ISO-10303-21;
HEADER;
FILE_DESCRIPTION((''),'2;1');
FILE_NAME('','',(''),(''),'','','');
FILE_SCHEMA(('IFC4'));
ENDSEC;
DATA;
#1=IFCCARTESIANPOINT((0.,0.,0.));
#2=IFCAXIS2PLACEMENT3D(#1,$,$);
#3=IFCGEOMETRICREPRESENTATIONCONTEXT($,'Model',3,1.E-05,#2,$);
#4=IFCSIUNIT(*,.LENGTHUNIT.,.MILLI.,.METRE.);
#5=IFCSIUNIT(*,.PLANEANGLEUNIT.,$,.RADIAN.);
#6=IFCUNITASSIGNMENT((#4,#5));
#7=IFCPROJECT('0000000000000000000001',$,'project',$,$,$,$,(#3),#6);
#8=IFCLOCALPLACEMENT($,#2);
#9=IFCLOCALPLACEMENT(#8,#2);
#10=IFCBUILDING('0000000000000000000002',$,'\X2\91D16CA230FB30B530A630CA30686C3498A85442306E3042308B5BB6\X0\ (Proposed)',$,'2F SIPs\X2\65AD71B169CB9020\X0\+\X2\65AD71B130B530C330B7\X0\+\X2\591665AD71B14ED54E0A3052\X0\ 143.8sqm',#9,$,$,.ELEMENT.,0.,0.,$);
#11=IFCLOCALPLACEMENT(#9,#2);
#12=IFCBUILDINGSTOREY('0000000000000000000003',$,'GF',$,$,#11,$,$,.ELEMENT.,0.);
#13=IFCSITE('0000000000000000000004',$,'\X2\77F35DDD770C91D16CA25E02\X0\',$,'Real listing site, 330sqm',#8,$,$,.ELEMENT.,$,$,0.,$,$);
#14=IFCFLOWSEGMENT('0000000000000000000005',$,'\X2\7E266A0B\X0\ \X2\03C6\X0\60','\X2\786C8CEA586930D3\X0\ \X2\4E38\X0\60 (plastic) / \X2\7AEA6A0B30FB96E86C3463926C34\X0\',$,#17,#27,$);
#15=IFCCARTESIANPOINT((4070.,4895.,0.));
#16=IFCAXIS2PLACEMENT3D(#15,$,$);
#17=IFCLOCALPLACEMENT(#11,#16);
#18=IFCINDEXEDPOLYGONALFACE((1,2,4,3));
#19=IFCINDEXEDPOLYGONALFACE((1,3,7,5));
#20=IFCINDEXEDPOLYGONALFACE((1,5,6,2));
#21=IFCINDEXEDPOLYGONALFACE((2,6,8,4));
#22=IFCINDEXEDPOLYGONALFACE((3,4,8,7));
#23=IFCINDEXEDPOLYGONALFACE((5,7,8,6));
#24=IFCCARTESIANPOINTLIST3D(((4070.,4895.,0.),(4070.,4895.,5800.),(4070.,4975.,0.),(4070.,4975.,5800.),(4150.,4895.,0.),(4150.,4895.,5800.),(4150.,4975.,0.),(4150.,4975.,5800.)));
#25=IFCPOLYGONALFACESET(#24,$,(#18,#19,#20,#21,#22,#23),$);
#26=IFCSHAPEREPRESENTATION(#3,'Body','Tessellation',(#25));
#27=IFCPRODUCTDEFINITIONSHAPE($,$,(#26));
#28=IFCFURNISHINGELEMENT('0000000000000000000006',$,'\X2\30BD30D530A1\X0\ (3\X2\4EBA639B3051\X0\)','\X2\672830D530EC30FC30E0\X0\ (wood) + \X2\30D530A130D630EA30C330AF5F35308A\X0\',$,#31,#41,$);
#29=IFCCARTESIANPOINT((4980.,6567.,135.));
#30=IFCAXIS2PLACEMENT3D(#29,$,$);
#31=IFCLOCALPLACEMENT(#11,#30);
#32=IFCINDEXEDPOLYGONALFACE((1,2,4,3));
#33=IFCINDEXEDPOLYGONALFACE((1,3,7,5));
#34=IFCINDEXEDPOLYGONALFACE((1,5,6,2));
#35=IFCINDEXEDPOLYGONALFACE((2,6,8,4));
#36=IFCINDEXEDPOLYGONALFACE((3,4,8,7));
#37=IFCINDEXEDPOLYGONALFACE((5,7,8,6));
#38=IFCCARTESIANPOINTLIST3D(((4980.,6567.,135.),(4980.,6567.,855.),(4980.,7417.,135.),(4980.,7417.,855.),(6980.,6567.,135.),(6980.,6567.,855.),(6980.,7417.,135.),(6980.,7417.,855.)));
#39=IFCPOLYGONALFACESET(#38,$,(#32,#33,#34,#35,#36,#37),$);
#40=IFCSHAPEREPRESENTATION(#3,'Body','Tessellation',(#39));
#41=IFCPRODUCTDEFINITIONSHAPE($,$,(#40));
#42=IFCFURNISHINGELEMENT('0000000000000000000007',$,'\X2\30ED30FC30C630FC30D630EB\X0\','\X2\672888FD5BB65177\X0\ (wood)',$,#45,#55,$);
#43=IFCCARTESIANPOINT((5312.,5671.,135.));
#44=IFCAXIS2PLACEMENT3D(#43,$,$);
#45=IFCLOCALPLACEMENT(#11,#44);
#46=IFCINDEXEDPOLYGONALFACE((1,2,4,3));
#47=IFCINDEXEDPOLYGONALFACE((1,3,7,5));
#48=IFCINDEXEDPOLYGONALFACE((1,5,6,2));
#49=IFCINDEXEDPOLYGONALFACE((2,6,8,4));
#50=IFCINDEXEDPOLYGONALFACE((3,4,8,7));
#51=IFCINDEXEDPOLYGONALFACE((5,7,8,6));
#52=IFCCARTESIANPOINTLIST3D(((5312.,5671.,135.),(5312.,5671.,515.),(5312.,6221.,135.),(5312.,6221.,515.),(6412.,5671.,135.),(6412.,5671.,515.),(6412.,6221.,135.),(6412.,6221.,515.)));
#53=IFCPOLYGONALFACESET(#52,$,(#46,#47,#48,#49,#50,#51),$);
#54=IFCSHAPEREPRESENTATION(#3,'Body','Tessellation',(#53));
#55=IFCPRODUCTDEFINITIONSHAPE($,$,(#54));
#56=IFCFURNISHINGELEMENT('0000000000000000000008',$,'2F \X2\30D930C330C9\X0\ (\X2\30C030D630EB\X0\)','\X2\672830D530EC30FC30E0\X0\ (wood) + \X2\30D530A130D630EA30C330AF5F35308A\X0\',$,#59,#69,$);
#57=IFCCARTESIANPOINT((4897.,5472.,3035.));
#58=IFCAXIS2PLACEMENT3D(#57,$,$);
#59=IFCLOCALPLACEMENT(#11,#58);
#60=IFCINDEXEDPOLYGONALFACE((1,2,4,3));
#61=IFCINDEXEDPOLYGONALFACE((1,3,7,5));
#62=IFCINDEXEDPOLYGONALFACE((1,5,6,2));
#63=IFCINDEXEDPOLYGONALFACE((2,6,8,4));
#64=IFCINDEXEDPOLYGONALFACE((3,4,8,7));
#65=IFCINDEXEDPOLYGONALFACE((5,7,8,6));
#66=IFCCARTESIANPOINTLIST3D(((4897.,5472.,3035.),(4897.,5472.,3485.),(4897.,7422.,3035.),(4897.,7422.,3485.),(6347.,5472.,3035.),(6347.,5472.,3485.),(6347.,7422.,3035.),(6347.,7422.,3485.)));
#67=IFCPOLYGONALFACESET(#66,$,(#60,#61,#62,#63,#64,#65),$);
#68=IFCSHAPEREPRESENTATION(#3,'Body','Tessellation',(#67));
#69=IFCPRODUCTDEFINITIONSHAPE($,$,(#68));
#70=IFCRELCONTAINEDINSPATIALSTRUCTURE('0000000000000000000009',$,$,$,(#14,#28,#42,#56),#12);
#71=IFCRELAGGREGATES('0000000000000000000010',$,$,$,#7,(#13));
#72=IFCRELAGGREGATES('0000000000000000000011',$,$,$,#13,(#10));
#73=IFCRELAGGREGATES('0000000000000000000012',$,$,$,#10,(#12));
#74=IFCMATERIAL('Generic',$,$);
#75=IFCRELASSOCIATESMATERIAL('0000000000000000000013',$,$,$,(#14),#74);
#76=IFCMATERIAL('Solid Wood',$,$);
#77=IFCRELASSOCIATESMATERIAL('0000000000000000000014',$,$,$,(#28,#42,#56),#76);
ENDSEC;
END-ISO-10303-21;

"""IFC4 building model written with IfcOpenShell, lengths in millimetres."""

from ifc_helpers import new_model, si_unit, frame, frame_2d, origin, place, context, project, spatial, rectangle, extrude, material, element, save


model = new_model("IFC4")

# Units and contexts
model_context = context("Model", 3, precision=1e-05, world=origin())
ifc_project = project(units=[si_unit("LENGTHUNIT", "METRE", prefix="MILLI"), si_unit("PLANEANGLEUNIT", "RADIAN")], contexts=[model_context])

# Site, building, storey
site_placement = place(None, origin())
site = spatial("IfcSite", under=ifc_project, at=site_placement, Name="石川県金沢市", ObjectType="Real listing site, 330sqm", CompositionType="ELEMENT", RefElevation=0.0)
building_placement = place(site_placement, origin())
building = spatial("IfcBuilding", under=site, at=building_placement, Name="金沢・サウナと水風呂のある家 (Proposed)", ObjectType="2F SIPs断熱構造+断熱サッシ+外断熱仕上げ 143.8sqm", CompositionType="ELEMENT", ElevationOfRefHeight=0.0, ElevationOfTerrain=0.0)
storey_placement = place(building_placement, origin())
storey = spatial("IfcBuildingStorey", under=building, at=storey_placement, Name="GF", CompositionType="ELEMENT", Elevation=0.0)

# Shared definitions
ifc_material_1 = material(Name="Solid Wood")

# Shared definitions
ifc_material_2 = material(Name="Generic")

# Flow segment
flow_segment_1_placement = place(storey_placement, frame((4070.0, 4895.0, 0.0)))
element("IfcFlowSegment", 1, at=flow_segment_1_placement, inside=storey, material=ifc_material_2, Name="縦樋 φ60", Description="硬質塩ビ 丸60 (plastic) / 竪樋・雨水排水", context=model_context, shape_type="SweptSolid", body=[
    extrude(rectangle(XDim=80.0, YDim=80.0, at=frame_2d((40.0, 40.0))), frame((4070.0, 4895.0, 0.0)), (0.0, 0.0, 1.0), 5800.0),
])

# Furnishing elements
furnishing_1_placement = place(storey_placement, frame((4980.0, 6567.0, 135.0)))
element("IfcFurnishingElement", 2, at=furnishing_1_placement, inside=storey, material=ifc_material_1, Name="ソファ (3人掛け)", Description="木フレーム (wood) + ファブリック張り", context=model_context, shape_type="SweptSolid", body=[
    extrude(rectangle(XDim=2000.0, YDim=850.0, at=frame_2d((1000.0, 425.0))), frame((4980.0, 6567.0, 135.0)), (0.0, 0.0, 1.0), 720.0),
])
furnishing_2_placement = place(storey_placement, frame((5312.0, 5671.0, 135.0)))
element("IfcFurnishingElement", 3, at=furnishing_2_placement, inside=storey, material=ifc_material_1, Name="ローテーブル", Description="木製家具 (wood)", context=model_context, shape_type="SweptSolid", body=[
    extrude(rectangle(XDim=1100.0, YDim=550.0, at=frame_2d((550.0, 275.0))), frame((5312.0, 5671.0, 135.0)), (0.0, 0.0, 1.0), 380.0),
])
furnishing_3_placement = place(storey_placement, frame((4897.0, 5472.0, 3035.0)))
element("IfcFurnishingElement", 4, at=furnishing_3_placement, inside=storey, material=ifc_material_1, Name="2F ベッド (ダブル)", Description="木フレーム (wood) + ファブリック張り", context=model_context, shape_type="SweptSolid", body=[
    extrude(rectangle(XDim=1450.0, YDim=1950.0, at=frame_2d((725.0, 975.0))), frame((4897.0, 5472.0, 3035.0)), (0.0, 0.0, 1.0), 450.0),
])

save(model, "model.ifc")
